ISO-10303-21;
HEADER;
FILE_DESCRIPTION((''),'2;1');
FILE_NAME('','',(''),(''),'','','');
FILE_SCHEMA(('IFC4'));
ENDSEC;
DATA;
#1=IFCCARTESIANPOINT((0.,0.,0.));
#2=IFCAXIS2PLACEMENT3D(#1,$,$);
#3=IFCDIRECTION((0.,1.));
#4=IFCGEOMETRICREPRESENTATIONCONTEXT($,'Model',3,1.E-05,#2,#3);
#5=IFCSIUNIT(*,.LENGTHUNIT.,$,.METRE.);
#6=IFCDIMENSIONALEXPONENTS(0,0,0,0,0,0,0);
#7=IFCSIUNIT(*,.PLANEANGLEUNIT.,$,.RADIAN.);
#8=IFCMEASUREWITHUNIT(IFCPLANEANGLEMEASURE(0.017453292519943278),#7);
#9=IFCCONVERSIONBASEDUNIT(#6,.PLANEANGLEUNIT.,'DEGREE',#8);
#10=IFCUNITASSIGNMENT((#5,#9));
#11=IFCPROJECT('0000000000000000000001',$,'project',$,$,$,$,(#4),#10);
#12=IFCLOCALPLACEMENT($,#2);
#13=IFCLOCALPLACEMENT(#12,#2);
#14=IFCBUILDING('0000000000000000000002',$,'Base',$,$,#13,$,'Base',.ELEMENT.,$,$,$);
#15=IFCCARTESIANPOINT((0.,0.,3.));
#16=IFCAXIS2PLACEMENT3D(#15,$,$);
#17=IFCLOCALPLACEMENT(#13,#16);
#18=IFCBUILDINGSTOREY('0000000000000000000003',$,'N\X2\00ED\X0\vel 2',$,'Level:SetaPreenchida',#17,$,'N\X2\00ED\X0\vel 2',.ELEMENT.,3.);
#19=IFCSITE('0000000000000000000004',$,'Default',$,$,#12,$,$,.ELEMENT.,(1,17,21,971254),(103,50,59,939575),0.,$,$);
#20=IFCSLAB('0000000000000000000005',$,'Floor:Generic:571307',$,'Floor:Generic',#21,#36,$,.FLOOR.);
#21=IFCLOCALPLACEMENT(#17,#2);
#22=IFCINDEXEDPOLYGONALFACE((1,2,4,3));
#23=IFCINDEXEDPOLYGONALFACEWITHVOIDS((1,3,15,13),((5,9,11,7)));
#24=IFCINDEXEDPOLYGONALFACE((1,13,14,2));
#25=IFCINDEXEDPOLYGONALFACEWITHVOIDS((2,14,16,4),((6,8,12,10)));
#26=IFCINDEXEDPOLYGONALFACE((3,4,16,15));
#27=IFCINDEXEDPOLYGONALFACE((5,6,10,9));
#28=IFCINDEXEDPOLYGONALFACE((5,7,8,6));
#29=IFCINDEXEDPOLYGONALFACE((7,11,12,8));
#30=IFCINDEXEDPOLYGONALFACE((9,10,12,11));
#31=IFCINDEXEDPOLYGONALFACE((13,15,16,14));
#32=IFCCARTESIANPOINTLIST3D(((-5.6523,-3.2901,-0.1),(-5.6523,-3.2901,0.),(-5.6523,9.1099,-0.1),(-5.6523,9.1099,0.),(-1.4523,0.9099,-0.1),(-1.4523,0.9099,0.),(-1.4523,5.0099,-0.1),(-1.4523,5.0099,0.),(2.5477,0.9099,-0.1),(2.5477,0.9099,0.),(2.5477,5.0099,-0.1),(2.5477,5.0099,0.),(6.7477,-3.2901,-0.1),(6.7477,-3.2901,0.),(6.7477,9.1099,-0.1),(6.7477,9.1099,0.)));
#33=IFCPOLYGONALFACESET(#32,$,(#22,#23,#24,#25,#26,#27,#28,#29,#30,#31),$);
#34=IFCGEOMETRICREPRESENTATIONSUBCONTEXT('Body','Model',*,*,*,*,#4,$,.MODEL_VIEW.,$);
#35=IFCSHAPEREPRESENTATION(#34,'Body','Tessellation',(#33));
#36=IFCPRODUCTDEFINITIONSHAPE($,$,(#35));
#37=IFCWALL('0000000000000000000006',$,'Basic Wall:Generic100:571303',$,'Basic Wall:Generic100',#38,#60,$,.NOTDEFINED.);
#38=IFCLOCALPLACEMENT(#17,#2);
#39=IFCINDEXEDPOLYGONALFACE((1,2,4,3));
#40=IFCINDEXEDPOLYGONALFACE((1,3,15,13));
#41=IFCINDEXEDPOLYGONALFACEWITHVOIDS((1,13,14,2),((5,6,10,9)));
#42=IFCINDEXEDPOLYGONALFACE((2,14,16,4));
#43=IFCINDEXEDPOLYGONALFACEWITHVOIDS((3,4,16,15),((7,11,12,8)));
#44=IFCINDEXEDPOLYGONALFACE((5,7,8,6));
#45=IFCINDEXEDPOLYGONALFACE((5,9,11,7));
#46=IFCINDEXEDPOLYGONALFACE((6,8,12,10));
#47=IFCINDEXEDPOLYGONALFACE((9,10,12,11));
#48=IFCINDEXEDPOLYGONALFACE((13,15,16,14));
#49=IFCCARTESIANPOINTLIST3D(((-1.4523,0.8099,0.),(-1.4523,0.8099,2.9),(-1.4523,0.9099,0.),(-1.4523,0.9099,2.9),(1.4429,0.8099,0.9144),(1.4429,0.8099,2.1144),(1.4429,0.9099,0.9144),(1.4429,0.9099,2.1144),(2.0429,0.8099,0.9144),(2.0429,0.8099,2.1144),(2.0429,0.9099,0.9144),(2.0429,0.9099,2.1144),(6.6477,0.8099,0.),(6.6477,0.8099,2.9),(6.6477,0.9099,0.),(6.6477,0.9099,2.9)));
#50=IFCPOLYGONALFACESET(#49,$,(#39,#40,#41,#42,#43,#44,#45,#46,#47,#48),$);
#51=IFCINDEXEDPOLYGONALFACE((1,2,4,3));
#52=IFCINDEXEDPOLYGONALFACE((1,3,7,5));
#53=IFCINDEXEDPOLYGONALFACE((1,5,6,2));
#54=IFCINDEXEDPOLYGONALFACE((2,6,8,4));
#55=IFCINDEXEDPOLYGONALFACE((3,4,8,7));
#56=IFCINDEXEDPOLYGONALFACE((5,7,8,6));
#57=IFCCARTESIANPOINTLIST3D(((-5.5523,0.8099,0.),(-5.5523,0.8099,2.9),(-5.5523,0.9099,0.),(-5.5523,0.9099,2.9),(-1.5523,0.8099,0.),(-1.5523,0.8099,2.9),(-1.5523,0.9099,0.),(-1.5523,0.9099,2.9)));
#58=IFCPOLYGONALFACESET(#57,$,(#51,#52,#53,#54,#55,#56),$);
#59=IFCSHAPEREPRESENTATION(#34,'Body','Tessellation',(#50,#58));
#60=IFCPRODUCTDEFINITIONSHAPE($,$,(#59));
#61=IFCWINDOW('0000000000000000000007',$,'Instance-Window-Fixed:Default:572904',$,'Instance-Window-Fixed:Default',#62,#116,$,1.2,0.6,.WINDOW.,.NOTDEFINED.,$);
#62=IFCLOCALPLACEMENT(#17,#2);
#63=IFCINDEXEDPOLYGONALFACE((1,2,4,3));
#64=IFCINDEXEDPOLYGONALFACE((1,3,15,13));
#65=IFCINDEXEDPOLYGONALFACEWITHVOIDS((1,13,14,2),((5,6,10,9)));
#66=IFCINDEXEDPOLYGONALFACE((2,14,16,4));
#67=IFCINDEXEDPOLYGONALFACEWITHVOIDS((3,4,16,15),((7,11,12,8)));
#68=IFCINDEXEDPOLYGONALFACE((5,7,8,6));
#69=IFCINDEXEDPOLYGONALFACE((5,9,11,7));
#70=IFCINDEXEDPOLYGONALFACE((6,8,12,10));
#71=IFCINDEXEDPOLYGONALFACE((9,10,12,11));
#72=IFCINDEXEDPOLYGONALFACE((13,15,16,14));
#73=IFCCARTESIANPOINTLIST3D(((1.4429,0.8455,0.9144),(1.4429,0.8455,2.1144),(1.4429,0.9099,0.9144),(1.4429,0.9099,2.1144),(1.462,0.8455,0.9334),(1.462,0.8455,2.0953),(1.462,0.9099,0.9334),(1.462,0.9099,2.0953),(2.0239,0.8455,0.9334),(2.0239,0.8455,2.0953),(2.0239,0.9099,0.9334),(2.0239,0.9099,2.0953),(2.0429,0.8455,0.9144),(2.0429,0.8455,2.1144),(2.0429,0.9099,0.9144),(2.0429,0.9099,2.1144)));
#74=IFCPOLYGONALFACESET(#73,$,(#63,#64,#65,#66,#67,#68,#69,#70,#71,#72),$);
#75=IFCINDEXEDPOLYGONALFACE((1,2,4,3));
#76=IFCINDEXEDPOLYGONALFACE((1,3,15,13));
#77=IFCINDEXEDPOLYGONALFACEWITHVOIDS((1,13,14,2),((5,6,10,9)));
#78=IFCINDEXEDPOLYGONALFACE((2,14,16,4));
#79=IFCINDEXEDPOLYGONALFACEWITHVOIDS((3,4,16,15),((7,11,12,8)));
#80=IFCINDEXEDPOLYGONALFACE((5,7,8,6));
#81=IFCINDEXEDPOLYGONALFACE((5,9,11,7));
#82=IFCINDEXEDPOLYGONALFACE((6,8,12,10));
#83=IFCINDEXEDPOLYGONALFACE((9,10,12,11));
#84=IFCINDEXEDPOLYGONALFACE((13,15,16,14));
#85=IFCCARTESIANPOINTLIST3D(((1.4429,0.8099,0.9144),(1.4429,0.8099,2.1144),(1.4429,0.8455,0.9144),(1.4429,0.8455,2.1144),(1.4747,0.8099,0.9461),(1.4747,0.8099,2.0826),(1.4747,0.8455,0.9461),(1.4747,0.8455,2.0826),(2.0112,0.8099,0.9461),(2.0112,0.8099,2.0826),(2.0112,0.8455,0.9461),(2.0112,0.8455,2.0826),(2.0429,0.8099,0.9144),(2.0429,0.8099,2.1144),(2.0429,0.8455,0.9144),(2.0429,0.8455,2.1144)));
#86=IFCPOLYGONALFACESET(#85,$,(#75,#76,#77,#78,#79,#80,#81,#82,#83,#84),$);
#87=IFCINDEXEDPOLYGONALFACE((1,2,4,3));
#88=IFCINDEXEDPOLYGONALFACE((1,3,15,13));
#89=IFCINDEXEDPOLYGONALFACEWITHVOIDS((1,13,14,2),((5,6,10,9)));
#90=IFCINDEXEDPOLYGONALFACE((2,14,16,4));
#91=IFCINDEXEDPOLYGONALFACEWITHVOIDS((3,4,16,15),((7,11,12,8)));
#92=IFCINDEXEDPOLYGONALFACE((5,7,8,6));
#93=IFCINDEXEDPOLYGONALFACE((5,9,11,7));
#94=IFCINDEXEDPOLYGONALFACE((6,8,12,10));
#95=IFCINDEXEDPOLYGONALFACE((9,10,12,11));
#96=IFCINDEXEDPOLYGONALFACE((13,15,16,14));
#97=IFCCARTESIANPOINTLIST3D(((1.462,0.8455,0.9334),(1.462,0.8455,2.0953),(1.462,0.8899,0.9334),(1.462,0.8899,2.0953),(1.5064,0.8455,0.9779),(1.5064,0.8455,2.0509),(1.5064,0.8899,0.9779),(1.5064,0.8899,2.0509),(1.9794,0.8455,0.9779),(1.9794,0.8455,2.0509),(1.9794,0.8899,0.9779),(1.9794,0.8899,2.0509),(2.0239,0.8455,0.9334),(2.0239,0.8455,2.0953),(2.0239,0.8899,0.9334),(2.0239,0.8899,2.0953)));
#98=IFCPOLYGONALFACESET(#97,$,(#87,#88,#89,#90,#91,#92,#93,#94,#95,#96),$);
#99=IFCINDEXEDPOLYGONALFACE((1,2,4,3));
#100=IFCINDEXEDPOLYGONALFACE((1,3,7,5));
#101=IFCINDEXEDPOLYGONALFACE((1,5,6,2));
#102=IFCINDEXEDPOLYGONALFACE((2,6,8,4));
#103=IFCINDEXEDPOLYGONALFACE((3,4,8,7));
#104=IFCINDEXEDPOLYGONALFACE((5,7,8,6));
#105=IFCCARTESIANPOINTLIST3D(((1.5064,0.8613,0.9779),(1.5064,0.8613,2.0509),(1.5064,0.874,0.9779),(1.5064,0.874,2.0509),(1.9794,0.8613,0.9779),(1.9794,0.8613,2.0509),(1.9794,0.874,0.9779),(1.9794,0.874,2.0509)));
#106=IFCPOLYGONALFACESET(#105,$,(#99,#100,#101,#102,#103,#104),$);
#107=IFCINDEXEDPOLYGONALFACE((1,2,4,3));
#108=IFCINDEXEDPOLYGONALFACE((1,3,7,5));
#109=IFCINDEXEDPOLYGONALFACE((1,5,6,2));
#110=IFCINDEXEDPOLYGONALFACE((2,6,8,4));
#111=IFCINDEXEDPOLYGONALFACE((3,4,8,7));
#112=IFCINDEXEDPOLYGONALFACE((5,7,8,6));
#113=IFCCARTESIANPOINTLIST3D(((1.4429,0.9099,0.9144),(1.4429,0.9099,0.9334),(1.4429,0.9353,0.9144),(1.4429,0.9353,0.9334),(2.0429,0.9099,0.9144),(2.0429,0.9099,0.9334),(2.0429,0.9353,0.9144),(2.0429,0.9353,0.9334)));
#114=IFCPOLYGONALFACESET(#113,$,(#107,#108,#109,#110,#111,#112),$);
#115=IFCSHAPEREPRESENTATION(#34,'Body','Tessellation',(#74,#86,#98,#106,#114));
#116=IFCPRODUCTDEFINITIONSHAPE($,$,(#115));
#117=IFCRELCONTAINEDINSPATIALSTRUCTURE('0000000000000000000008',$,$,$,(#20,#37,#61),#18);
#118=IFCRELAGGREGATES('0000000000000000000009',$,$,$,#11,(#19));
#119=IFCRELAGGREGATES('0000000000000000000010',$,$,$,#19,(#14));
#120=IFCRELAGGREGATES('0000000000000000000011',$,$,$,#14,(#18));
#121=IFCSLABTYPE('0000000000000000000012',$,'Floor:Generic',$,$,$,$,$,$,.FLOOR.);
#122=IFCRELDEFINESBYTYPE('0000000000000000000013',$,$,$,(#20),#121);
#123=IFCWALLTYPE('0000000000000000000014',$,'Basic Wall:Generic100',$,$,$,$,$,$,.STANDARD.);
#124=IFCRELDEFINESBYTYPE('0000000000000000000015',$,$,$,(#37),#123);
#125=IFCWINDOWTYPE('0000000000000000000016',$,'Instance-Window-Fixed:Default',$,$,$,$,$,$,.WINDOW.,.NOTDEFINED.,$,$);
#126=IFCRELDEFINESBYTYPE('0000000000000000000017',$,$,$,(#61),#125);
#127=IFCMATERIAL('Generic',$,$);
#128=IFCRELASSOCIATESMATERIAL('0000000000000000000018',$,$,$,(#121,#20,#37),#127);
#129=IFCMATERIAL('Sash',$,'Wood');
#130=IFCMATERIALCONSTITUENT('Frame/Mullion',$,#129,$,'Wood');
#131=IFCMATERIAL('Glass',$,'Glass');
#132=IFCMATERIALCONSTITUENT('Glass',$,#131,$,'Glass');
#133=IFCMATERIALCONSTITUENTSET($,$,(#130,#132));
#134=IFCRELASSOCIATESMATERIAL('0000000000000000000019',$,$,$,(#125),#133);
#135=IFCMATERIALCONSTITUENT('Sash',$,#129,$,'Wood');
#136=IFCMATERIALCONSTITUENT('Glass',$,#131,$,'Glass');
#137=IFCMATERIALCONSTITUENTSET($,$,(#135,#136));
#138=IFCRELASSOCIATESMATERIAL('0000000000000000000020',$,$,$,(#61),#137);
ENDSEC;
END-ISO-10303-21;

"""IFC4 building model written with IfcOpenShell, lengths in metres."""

from ifc_helpers import new_model, entity, si_unit, converted_unit, direction, frame, origin, place, context, subcontext, project, spatial, indexed_curve, outline, extrude, source, transform, mapped, material, constituent, constituent_set, type_object, type_shapes, element, fill, save


model = new_model("IFC4")

# Units and contexts
model_context = context("Model", 3, precision=1e-05, world=origin(), true_north=direction((0.0, 1.0)))
body_context = subcontext(model_context, "Body", "Model", "MODEL_VIEW")
ifc_project = project(units=[si_unit("LENGTHUNIT", "METRE"), converted_unit("PLANEANGLEUNIT", "DEGREE", entity("IfcPlaneAngleMeasure", 0.017453292519943278), si_unit("PLANEANGLEUNIT", "RADIAN"), dimensions=[0, 0, 0, 0, 0, 0, 0])], contexts=[model_context])

# Site, building, storey
site_placement = place(None, origin())
site = spatial("IfcSite", under=ifc_project, at=site_placement, Name="Default", CompositionType="ELEMENT", RefLatitude=(1, 17, 21, 971254), RefLongitude=(103, 50, 59, 939575), RefElevation=0.0)
building_placement = place(site_placement, origin())
building = spatial("IfcBuilding", under=site, at=building_placement, Name="Base", LongName="Base", CompositionType="ELEMENT")
storey_placement = place(building_placement, frame((0.0, 0.0, 3.0)))
storey = spatial("IfcBuildingStorey", under=building, at=storey_placement, Name="Nível 2", ObjectType="Level:SetaPreenchida", LongName="Nível 2", CompositionType="ELEMENT", Elevation=3.0)

# Slab, opening
ifc_material_1 = material(Name="Generic")
slab_type = type_object("IfcSlabType", Name="Floor:Generic", PredefinedType="FLOOR", material=ifc_material_1)
slab_placement = place(storey_placement, origin())
slab = element("IfcSlab", 1, at=slab_placement, inside=storey, type_object=slab_type, material=ifc_material_1, Name="Floor:Generic:571307", ObjectType="Floor:Generic", PredefinedType="FLOOR", context=body_context, shape_type="SweptSolid", body=[
    extrude(outline(indexed_curve([(-6.2, -6.2), (6.2, -6.2), (6.2, 6.2), (-6.2, 6.2), (-6.2, -6.2)], self_intersect=False), holes=[indexed_curve([(2.0, 2.0), (2.0, -2.1), (-2.0, -2.1), (-2.0, 2.0), (2.0, 2.0)], self_intersect=False)]), frame((0.5477, 2.9099, -0.1), z_axis=(0.0, 0.0, 1.0), x_axis=(-1.0, 0.0, 0.0)), (0.0, 0.0, 1.0), 0.1),
])
opening_1_placement = place(slab_placement, origin())
element("IfcOpeningElement", 2, at=opening_1_placement, cuts=slab, PredefinedType="OPENING", context=body_context, shape_type="SweptSolid", body=[
    extrude(outline(indexed_curve([(-2.05, -2.0), (2.05, -2.0), (2.05, 2.0), (-2.05, 2.0), (-2.05, -2.0)], self_intersect=False)), frame((0.5477, 2.9599, 0.0), z_axis=(0.0, 0.0, -1.0), x_axis=(0.0, 1.0, 0.0)), (0.0, 0.0, 1.0), 12.4),
])

# Wall, openings, window
wall_type = type_object("IfcWallType", Name="Basic Wall:Generic100", PredefinedType="STANDARD")
wall_placement = place(storey_placement, frame((6.6477, 0.8599, 0.0), z_axis=(0.0, 0.0, 1.0), x_axis=(-1.0, 0.0, 0.0)))
wall = element("IfcWall", 3, at=wall_placement, inside=storey, type_object=wall_type, material=ifc_material_1, Name="Basic Wall:Generic100:571303", ObjectType="Basic Wall:Generic100", PredefinedType="NOTDEFINED", context=body_context, shape_type="SweptSolid", body=[
    extrude(outline(indexed_curve([(-4.05, -0.05), (-0.05, -0.05), (0.05, -0.05), (4.05, -0.05), (4.05, 0.05), (0.05, 0.05), (-0.05, 0.05), (-4.05, 0.05), (-4.05, -0.05)], self_intersect=False)), frame((4.05, 0.0, 0.0)), (0.0, 0.0, 1.0), 2.9),
    extrude(outline(indexed_curve([(-2.0, -0.05), (2.0, -0.05), (2.0, 0.05), (-2.0, 0.05), (-2.0, -0.05)], self_intersect=False)), frame((10.2, 0.0, 0.0), z_axis=(0.0, 0.0, 1.0), x_axis=(-1.0, 0.0, 0.0)), (0.0, 0.0, 1.0), 2.9),
])
opening_2_placement = place(storey_placement, frame((6.6477, 0.8599, 0.0), z_axis=(0.0, 0.0, 1.0), x_axis=(-1.0, 0.0, 0.0)))
element("IfcOpeningElement", 4, at=opening_2_placement, cuts=wall, PredefinedType="OPENING", context=body_context, shape_type="SweptSolid", body=[
    extrude(outline(indexed_curve([(-0.6, -0.3), (0.6, -0.3), (0.6, 0.3), (-0.6, 0.3), (-0.6, -0.3)], self_intersect=False)), frame((4.9048, -0.05, 1.5144), z_axis=(0.0, 1.0, 0.0), x_axis=(0.0, 0.0, 1.0)), (0.0, 0.0, 1.0), 0.1),
])
opening_3_placement = place(wall_placement, frame((5.2048, 0.05, 0.9144)))
opening_3 = element("IfcOpeningElement", 5, at=opening_3_placement, cuts=wall, PredefinedType="OPENING", context=body_context, shape_type="SweptSolid", body=[
    extrude(outline(indexed_curve([(1.2, 0.6), (0.0, 0.6), (0.0, 0.0), (1.2, 0.0), (1.2, 0.6)], self_intersect=False)), frame((0.0, 0.0, 0.0), z_axis=(0.0, -1.0, 0.0), x_axis=(0.0, 0.0, 1.0)), (0.0, 0.0, 1.0), 0.1),
])
ifc_material_2 = material(Name="Sash", Category="Wood")
ifc_constituent_1 = constituent(ifc_material_2, Name="Sash", Category="Wood")
ifc_material_3 = material(Name="Glass", Category="Glass")
ifc_constituent_2 = constituent(ifc_material_3, Name="Glass", Category="Glass")
ifc_constituent_set_1 = constituent_set(constituents=[ifc_constituent_1, ifc_constituent_2])
ifc_constituent_3 = constituent(ifc_material_2, Name="Frame/Mullion", Category="Wood")
ifc_constituent_4 = constituent(ifc_material_3, Name="Glass", Category="Glass")
ifc_constituent_set_2 = constituent_set(constituents=[ifc_constituent_3, ifc_constituent_4])
window_type = type_object("IfcWindowType", Name="Instance-Window-Fixed:Default", PartitioningType="NOTDEFINED", PredefinedType="WINDOW", material=ifc_constituent_set_2)
shared_shape = source(origin(), body_context, "Body", "SweptSolid", [
    extrude(outline(indexed_curve([(-0.6, -0.3), (0.6, -0.3), (0.6, 0.3), (-0.6, 0.3), (-0.6, -0.3)], self_intersect=False), holes=[indexed_curve([(-0.5809, -0.2809), (-0.5809, 0.281), (0.581, 0.281), (0.581, -0.2809), (-0.5809, -0.2809)], self_intersect=False)]), frame((0.3, 0.0356, 0.6), z_axis=(0.0, 1.0, 0.0), x_axis=(0.0, 0.0, -1.0)), (0.0, 0.0, 1.0), 0.0644),
    extrude(outline(indexed_curve([(-0.3, -0.6), (0.3, -0.6), (0.3, 0.6), (-0.3, 0.6), (-0.3, -0.6)], self_intersect=False), holes=[indexed_curve([(-0.2683, -0.5682), (-0.2683, 0.5683), (0.2682, 0.5683), (0.2682, -0.5682), (-0.2683, -0.5682)], self_intersect=False)]), frame((0.3, 0.0, 0.6), z_axis=(0.0, 1.0, 0.0), x_axis=(1.0, 0.0, 0.0)), (0.0, 0.0, 1.0), 0.0356),
    extrude(outline(indexed_curve([(-0.2809, -0.581), (0.2809, -0.581), (0.2809, 0.581), (-0.2809, 0.581), (-0.2809, -0.581)], self_intersect=False), holes=[indexed_curve([(-0.2365, -0.5365), (-0.2365, 0.5365), (0.2365, 0.5365), (0.2365, -0.5365), (-0.2365, -0.5365)], self_intersect=False)]), frame((0.3, 0.0356, 0.6), z_axis=(0.0, 1.0, 0.0), x_axis=(1.0, 0.0, 0.0)), (0.0, 0.0, 1.0), 0.0444),
    extrude(outline(indexed_curve([(-0.0063, -0.2365), (0.0063, -0.2365), (0.0063, 0.2365), (-0.0063, 0.2365), (-0.0063, -0.2365)], self_intersect=False)), frame((0.3, 0.0578, 0.0635), z_axis=(0.0, 0.0, 1.0), x_axis=(0.0, 1.0, 0.0)), (0.0, 0.0, 1.0), 1.073),
    extrude(outline(indexed_curve([(-0.0127, -0.3), (0.0127, -0.3), (0.0127, 0.3), (-0.0127, 0.3), (-0.0127, -0.3)], self_intersect=False)), frame((0.3, 0.1127, 0.0), z_axis=(0.0, 0.0, 1.0), x_axis=(0.0, -1.0, 0.0)), (0.0, 0.0, 1.0), 0.019),
])
type_shapes(window_type, [shared_shape])
window_placement = place(opening_3_placement, frame((0.0, 0.0, 0.0), z_axis=(0.0, 0.0, 1.0), x_axis=(-1.0, 0.0, 0.0)))
window = element("IfcWindow", 6, at=window_placement, inside=storey, type_object=window_type, material=ifc_constituent_set_1, Name="Instance-Window-Fixed:Default:572904", ObjectType="Instance-Window-Fixed:Default", OverallHeight=1.2, OverallWidth=0.6, PartitioningType="NOTDEFINED", PredefinedType="WINDOW", context=body_context, shape_type="MappedRepresentation", body=[
    mapped(shared_shape, transform((0.0, 0.0, 0.0), scale=1.0)),
])
fill(opening_3, window)

save(model, "model.ifc")
